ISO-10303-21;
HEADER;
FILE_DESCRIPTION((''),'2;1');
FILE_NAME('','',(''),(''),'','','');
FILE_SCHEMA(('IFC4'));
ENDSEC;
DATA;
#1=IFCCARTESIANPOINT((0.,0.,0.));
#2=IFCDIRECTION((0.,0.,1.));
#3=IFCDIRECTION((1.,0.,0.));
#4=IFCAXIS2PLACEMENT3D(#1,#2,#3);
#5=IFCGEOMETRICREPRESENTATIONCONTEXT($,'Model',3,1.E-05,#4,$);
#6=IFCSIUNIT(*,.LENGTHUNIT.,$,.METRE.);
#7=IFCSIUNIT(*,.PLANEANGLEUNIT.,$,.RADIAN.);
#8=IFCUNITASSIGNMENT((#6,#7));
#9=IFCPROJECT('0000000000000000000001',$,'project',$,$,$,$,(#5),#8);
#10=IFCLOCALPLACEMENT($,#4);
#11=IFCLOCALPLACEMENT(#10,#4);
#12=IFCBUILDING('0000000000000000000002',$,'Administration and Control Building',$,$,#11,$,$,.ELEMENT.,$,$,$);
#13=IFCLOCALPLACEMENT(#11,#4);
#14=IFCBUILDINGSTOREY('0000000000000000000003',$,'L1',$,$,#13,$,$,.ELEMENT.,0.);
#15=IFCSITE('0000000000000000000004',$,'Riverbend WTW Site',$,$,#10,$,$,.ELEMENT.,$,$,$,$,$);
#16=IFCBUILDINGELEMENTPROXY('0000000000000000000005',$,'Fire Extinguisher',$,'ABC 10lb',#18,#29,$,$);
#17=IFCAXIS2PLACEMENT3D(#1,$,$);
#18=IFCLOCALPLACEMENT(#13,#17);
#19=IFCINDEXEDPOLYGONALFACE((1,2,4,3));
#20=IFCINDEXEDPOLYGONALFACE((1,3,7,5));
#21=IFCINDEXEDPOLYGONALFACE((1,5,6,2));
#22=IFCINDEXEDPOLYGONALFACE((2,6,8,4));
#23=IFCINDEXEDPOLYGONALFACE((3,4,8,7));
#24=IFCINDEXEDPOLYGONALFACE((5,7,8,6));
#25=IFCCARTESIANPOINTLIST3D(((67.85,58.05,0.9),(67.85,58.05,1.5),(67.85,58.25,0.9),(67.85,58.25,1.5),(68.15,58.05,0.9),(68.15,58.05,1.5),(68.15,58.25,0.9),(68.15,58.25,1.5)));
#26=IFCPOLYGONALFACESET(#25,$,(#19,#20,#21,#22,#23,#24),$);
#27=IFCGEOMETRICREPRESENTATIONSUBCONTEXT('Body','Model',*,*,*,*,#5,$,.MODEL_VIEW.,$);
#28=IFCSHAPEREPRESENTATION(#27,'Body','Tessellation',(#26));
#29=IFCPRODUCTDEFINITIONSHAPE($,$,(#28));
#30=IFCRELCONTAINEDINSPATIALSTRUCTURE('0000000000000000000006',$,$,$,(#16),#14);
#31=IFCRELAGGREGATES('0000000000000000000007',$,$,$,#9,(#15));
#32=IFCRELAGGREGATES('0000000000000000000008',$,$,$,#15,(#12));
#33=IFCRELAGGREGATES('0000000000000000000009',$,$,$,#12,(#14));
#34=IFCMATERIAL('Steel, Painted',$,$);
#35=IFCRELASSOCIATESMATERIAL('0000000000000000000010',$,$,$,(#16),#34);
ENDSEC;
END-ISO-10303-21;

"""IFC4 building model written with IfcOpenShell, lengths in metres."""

from ifc_helpers import new_model, si_unit, frame, origin_with_axes, origin_2d, place, context, subcontext, project, spatial, rectangle, extrude, material, element, save


model = new_model("IFC4")

# Units and contexts
model_context = context("Model", 3, precision=1e-05, world=origin_with_axes())
body_context = subcontext(model_context, "Body", "Model", "MODEL_VIEW")
ifc_project = project(units=[si_unit("LENGTHUNIT", "METRE"), si_unit("PLANEANGLEUNIT", "RADIAN")], contexts=[model_context])

# Site, building, storey
site_placement = place(None, origin_with_axes())
site = spatial("IfcSite", under=ifc_project, at=site_placement, Name="Riverbend WTW Site", CompositionType="ELEMENT")
building_placement = place(site_placement, origin_with_axes())
building = spatial("IfcBuilding", under=site, at=building_placement, Name="Administration and Control Building", CompositionType="ELEMENT")
storey_placement = place(building_placement, origin_with_axes())
storey = spatial("IfcBuildingStorey", under=building, at=storey_placement, Name="L1", CompositionType="ELEMENT", Elevation=0.0)

# Building element proxy
ifc_material_1 = material(Name="Steel, Painted")
proxy_1_placement = place(None, frame((68.0, 58.15, 1.2), z_axis=(0.0, 0.0, 1.0), x_axis=(1.0, 0.0, 0.0)))
element("IfcBuildingElementProxy", 1, at=proxy_1_placement, inside=storey, material=ifc_material_1, Name="Fire Extinguisher", ObjectType="ABC 10lb", context=body_context, shape_type="SweptSolid", body=[
    extrude(rectangle(XDim=0.3, YDim=0.2, at=origin_2d()), frame((0.0, 0.0, -0.3), z_axis=(0.0, 0.0, 1.0), x_axis=(1.0, 0.0, 0.0)), (0.0, 0.0, 1.0), 0.6),
])

save(model, "model.ifc")
